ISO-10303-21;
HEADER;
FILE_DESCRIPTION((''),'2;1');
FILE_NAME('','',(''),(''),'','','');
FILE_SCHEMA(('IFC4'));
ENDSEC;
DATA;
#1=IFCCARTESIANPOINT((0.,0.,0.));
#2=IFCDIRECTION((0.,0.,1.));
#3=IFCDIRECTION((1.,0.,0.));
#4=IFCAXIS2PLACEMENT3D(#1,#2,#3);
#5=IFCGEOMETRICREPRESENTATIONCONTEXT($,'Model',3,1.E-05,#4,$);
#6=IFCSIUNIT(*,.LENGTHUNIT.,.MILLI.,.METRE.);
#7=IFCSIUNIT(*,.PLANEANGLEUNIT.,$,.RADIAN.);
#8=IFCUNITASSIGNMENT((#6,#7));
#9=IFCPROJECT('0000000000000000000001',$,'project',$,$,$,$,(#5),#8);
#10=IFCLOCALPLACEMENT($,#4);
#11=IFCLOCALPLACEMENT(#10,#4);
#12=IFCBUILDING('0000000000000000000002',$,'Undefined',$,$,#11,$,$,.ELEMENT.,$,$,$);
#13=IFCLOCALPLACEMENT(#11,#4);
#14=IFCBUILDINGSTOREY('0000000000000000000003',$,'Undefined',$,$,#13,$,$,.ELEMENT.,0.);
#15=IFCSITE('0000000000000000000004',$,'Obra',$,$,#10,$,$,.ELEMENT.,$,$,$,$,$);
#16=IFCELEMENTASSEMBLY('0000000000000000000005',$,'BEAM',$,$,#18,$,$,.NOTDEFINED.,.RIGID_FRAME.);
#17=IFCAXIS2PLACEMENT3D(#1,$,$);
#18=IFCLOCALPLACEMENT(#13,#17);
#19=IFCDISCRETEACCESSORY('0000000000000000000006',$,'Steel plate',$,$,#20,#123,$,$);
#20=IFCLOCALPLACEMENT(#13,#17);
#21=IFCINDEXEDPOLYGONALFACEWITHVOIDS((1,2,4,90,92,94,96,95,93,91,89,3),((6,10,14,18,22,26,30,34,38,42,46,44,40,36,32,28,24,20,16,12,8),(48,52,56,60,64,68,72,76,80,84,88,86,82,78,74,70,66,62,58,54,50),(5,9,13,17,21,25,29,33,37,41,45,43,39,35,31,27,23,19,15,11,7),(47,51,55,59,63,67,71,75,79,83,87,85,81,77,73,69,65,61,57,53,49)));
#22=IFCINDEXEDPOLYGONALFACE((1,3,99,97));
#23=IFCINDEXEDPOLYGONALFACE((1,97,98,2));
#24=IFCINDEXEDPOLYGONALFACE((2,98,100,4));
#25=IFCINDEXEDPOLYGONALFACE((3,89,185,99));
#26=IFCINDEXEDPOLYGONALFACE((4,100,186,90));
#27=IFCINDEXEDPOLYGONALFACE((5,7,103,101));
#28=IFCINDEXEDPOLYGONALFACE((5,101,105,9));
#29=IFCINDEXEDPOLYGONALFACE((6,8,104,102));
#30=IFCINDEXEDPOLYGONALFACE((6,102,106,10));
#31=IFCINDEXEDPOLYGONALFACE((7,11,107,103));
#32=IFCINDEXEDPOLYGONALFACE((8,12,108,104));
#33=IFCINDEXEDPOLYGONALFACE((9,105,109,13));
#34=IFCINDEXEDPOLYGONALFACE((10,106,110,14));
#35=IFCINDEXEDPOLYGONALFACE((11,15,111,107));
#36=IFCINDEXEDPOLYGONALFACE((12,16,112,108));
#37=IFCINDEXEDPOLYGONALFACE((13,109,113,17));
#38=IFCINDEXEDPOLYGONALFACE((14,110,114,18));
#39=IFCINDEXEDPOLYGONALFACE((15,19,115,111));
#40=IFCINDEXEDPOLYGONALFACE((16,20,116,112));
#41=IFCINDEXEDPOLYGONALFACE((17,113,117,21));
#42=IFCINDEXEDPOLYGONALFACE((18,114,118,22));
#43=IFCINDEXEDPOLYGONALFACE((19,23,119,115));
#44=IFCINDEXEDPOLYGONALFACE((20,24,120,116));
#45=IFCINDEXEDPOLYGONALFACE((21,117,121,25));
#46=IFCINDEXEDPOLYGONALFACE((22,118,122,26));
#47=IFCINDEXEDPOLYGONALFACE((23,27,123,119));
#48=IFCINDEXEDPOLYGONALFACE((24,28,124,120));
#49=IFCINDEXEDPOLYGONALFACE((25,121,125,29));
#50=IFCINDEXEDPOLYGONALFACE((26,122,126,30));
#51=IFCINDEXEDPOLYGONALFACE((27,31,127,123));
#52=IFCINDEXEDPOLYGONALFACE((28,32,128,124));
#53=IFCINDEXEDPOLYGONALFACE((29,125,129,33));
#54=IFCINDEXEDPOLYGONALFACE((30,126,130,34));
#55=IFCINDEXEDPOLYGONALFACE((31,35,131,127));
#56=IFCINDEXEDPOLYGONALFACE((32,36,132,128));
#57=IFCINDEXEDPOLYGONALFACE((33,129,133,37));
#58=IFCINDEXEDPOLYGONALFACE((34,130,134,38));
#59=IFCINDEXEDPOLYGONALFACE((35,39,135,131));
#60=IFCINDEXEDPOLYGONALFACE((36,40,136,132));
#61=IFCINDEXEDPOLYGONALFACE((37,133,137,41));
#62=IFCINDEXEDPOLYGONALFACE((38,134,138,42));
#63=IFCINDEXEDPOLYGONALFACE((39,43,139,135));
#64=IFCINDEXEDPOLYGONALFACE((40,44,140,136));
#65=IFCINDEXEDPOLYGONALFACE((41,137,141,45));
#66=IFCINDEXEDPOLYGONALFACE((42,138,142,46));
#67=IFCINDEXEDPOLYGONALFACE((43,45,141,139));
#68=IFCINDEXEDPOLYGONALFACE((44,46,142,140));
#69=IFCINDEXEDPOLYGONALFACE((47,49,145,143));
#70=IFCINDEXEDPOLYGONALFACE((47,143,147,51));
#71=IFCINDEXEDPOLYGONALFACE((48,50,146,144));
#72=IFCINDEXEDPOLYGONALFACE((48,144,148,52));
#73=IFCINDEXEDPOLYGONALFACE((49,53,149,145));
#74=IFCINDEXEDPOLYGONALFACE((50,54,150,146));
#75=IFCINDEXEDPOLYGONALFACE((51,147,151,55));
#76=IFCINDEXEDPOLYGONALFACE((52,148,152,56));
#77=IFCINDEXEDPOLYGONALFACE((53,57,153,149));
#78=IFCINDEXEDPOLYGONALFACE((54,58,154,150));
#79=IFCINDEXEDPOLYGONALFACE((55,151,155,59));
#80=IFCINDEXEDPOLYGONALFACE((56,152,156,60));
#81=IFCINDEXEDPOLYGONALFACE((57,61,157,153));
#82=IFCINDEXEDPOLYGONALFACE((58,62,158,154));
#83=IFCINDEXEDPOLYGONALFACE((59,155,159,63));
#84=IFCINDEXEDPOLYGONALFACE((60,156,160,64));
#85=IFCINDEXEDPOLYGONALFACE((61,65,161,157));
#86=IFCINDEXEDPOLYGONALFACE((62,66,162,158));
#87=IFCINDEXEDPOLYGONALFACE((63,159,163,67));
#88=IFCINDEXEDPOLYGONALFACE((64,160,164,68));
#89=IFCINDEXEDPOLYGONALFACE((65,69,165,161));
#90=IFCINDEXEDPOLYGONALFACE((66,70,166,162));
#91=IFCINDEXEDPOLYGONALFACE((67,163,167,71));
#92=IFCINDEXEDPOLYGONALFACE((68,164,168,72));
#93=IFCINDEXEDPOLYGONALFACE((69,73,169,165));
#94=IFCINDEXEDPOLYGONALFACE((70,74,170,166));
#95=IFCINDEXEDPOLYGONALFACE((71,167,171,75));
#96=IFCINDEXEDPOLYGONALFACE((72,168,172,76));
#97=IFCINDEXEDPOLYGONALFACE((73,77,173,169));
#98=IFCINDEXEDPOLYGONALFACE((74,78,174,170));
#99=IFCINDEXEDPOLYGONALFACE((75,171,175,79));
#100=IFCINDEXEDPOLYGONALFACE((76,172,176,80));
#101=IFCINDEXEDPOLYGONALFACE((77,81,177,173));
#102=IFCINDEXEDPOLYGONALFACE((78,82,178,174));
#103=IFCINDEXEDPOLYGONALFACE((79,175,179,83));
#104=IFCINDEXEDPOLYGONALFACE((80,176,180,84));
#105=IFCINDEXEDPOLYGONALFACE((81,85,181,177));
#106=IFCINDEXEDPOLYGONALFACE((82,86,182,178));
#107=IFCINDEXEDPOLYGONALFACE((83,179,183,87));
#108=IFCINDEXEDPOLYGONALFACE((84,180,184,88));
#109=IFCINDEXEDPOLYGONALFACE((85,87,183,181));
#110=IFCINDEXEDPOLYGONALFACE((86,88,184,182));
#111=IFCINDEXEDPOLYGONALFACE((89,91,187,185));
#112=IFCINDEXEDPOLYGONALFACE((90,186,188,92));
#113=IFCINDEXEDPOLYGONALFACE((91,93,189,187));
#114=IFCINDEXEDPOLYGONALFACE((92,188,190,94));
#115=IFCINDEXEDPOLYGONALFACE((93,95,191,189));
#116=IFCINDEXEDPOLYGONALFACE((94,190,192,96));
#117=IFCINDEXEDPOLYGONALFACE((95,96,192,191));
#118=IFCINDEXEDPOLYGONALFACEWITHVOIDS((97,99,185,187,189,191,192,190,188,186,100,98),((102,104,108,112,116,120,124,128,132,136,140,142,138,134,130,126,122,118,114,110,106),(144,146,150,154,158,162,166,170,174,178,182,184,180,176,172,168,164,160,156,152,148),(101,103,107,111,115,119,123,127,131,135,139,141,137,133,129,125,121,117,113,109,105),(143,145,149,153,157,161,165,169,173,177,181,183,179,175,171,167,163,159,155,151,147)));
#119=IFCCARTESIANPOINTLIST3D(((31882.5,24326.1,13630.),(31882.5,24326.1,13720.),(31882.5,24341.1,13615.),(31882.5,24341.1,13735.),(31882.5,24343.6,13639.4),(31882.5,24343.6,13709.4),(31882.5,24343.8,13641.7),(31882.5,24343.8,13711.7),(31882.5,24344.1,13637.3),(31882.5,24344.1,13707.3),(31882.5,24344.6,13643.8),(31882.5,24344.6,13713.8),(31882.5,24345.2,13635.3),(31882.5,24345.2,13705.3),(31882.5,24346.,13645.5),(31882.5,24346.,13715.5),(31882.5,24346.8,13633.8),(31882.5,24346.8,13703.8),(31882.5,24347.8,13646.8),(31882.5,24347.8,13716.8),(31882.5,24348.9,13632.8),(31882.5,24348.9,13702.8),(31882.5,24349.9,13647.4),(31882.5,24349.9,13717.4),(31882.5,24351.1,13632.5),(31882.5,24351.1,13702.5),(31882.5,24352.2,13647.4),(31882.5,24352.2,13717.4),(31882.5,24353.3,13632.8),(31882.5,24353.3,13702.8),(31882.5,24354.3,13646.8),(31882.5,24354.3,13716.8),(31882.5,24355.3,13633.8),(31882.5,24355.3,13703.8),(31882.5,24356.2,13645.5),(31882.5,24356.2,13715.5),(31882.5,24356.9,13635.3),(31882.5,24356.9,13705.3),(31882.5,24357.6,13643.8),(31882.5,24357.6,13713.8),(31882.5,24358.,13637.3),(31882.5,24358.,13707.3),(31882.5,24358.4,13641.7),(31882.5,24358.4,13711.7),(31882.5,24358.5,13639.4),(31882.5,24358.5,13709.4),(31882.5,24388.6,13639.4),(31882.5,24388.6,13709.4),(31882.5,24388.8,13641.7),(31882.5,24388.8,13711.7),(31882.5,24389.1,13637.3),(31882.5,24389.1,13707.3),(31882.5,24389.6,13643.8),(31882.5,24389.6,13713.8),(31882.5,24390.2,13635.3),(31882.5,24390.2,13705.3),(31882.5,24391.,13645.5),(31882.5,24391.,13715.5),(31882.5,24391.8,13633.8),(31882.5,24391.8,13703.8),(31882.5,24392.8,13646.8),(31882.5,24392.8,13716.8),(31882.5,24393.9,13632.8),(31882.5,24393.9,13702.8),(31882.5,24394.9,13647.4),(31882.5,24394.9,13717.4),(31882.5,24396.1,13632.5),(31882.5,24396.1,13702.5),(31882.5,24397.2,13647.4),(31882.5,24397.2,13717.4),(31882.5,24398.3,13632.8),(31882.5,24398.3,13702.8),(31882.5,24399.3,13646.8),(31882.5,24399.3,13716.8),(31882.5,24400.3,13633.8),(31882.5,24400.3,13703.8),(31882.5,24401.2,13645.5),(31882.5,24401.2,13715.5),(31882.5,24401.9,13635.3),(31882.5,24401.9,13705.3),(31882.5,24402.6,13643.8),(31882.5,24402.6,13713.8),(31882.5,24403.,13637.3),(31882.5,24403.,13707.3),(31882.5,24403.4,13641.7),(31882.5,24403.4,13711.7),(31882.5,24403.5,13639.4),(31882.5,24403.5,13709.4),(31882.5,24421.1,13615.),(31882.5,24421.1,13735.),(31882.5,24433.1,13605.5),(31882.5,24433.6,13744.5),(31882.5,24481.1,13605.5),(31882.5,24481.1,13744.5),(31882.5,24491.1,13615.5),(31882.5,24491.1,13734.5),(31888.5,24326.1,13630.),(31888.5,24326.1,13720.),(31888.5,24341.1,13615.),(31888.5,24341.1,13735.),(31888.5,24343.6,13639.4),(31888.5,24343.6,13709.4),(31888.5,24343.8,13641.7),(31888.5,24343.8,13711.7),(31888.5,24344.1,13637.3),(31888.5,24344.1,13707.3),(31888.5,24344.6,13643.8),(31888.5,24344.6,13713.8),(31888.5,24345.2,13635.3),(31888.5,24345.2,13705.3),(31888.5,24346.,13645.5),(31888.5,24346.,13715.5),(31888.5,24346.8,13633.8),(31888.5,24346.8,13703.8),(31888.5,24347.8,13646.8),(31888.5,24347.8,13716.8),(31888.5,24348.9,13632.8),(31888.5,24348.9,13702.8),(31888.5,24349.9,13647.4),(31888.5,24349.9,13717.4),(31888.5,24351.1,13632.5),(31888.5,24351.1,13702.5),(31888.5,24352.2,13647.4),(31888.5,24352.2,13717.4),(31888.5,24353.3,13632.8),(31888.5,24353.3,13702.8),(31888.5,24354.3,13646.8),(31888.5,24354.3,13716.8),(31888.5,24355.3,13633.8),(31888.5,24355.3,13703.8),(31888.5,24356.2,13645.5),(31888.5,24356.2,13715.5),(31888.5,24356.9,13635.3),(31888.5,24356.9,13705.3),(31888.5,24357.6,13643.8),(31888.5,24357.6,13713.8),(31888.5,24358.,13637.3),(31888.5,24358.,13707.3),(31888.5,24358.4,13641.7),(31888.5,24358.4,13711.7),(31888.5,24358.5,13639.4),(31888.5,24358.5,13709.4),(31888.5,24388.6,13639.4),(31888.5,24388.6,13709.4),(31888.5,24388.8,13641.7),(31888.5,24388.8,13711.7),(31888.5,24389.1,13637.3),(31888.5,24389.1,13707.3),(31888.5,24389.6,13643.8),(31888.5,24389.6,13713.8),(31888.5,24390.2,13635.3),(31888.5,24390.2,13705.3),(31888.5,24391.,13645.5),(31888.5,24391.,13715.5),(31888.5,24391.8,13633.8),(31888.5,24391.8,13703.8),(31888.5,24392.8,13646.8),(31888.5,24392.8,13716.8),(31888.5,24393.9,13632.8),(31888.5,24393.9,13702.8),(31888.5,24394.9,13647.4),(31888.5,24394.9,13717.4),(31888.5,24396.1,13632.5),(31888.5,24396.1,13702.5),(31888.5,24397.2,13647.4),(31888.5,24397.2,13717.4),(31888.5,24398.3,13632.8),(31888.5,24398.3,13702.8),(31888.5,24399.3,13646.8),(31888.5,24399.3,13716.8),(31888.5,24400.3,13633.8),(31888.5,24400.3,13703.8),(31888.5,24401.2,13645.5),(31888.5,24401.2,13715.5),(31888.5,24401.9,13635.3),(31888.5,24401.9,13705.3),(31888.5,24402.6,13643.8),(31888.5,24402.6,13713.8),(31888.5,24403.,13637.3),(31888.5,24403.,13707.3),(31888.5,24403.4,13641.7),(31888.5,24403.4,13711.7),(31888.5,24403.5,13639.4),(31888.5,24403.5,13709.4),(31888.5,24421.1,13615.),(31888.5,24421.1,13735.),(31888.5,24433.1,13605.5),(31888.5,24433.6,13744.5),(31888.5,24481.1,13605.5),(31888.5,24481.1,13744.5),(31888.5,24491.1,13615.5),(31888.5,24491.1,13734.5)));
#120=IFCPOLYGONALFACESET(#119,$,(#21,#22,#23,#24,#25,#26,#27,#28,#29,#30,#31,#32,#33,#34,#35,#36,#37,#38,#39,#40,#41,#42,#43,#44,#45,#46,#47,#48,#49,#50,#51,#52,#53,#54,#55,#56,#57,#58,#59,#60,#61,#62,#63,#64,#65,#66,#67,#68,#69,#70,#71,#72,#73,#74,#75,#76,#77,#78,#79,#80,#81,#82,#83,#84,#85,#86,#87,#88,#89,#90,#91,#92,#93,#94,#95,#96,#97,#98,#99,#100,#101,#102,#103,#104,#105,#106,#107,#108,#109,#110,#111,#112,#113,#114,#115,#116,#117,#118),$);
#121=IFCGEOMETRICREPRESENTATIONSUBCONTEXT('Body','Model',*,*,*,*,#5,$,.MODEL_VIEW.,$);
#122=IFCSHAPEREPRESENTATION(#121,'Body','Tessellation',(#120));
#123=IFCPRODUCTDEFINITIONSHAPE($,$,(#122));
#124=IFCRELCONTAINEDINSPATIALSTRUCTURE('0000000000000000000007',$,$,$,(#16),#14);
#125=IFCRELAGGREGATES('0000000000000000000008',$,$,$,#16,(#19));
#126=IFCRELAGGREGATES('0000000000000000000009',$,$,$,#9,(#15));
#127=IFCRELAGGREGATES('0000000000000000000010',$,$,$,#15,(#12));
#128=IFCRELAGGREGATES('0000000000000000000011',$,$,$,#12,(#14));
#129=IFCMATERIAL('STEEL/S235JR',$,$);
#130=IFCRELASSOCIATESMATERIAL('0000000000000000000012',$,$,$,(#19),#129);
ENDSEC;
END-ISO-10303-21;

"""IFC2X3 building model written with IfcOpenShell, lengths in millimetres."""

from ifc_helpers import new_model, si_unit, frame, origin_with_axes, origin_2d_with_axis, place, context, subcontext, project, spatial, polyline, circle, outline, extrude, source, transform, mapped, material, element, aggregate, save


model = new_model("IFC2X3")

# Units and contexts
model_context = context("Model", 3, precision=1e-05, world=origin_with_axes())
body_context = subcontext(model_context, "Body", "Model", "MODEL_VIEW")
ifc_project = project(units=[si_unit("LENGTHUNIT", "METRE", prefix="MILLI"), si_unit("PLANEANGLEUNIT", "RADIAN")], contexts=[model_context])

# Site, building, storey
site_placement = place(None, origin_with_axes())
site = spatial("IfcSite", under=ifc_project, at=site_placement, Name="Obra", CompositionType="ELEMENT")
building_placement = place(site_placement, origin_with_axes())
building = spatial("IfcBuilding", under=site, at=building_placement, Name="Undefined", CompositionType="ELEMENT")
storey_placement = place(building_placement, origin_with_axes())
storey = spatial("IfcBuildingStorey", under=building, at=storey_placement, Name="Undefined", CompositionType="ELEMENT", Elevation=0.0)

# Shared definitions
ifc_material_1 = material(Name="STEEL/S235JR")

# Element assembly, discrete accessory, opening
assembly_1_placement = place(storey_placement, origin_with_axes())
assembly_1 = element("IfcElementAssembly", 1, at=assembly_1_placement, inside=storey, Name="BEAM", AssemblyPlace="NOTDEFINED", PredefinedType="RIGID_FRAME")
discrete_accessory_1_placement = place(assembly_1_placement, frame((31885.5, 24491.1, 13615.5), z_axis=(-1.0, 0.0, 0.0), x_axis=(0.000001, -0.707107, -0.707107)))
discrete_accessory_1 = element("IfcDiscreteAccessory", 2, at=discrete_accessory_1_placement, material=ifc_material_1, Name="Steel plate", context=body_context, shape_type="SweptSolid", body=[
    extrude(outline(polyline([(0.0, 0.0), (14.1, 0.0), (48.1, 33.9), (49.9, 49.1), (106.4, 105.7), (106.4, 126.9), (42.8, 190.6), (21.6, 190.6), (-35.0, 134.0), (-50.6, 131.9), (-84.1, 98.3), (-84.1, 84.1), (0.0, 0.0)])), frame((0.0, 0.0, -3.0), z_axis=(0.0, 0.0, 1.0), x_axis=(1.0, 0.0, 0.0)), (0.0, 0.0, 1.0), 6.0),
])
shared_shape_1 = source(origin_with_axes(), body_context, "Body", "SweptSolid", [
    extrude(circle(Radius=7.5, at=origin_2d_with_axis()), frame((0.0, 2.4, 0.0), z_axis=(0.0, 1.0, 0.0), x_axis=(1.0, 0.0, 0.0)), (0.0, 0.0, 1.0), 6.2),
])
opening_1_placement = place(assembly_1_placement, frame((31880.0, 24373.6, 13710.0), z_axis=(0.0, -1.0, 0.0), x_axis=(0.0, 0.0, -1.0)))
element("IfcOpeningElement", 3, at=opening_1_placement, cuts=discrete_accessory_1, ObjectType="Opening", context=body_context, shape_type="MappedRepresentation", body=[
    mapped(shared_shape_1, transform((0.0, 0.0, -22.5))),
    mapped(shared_shape_1, transform((70.0, 0.0, -22.5))),
    mapped(shared_shape_1, transform((0.0, 0.0, 22.5))),
    mapped(shared_shape_1, transform((70.0, 0.0, 22.5))),
])

aggregate(assembly_1, [discrete_accessory_1])

save(model, "model.ifc")
